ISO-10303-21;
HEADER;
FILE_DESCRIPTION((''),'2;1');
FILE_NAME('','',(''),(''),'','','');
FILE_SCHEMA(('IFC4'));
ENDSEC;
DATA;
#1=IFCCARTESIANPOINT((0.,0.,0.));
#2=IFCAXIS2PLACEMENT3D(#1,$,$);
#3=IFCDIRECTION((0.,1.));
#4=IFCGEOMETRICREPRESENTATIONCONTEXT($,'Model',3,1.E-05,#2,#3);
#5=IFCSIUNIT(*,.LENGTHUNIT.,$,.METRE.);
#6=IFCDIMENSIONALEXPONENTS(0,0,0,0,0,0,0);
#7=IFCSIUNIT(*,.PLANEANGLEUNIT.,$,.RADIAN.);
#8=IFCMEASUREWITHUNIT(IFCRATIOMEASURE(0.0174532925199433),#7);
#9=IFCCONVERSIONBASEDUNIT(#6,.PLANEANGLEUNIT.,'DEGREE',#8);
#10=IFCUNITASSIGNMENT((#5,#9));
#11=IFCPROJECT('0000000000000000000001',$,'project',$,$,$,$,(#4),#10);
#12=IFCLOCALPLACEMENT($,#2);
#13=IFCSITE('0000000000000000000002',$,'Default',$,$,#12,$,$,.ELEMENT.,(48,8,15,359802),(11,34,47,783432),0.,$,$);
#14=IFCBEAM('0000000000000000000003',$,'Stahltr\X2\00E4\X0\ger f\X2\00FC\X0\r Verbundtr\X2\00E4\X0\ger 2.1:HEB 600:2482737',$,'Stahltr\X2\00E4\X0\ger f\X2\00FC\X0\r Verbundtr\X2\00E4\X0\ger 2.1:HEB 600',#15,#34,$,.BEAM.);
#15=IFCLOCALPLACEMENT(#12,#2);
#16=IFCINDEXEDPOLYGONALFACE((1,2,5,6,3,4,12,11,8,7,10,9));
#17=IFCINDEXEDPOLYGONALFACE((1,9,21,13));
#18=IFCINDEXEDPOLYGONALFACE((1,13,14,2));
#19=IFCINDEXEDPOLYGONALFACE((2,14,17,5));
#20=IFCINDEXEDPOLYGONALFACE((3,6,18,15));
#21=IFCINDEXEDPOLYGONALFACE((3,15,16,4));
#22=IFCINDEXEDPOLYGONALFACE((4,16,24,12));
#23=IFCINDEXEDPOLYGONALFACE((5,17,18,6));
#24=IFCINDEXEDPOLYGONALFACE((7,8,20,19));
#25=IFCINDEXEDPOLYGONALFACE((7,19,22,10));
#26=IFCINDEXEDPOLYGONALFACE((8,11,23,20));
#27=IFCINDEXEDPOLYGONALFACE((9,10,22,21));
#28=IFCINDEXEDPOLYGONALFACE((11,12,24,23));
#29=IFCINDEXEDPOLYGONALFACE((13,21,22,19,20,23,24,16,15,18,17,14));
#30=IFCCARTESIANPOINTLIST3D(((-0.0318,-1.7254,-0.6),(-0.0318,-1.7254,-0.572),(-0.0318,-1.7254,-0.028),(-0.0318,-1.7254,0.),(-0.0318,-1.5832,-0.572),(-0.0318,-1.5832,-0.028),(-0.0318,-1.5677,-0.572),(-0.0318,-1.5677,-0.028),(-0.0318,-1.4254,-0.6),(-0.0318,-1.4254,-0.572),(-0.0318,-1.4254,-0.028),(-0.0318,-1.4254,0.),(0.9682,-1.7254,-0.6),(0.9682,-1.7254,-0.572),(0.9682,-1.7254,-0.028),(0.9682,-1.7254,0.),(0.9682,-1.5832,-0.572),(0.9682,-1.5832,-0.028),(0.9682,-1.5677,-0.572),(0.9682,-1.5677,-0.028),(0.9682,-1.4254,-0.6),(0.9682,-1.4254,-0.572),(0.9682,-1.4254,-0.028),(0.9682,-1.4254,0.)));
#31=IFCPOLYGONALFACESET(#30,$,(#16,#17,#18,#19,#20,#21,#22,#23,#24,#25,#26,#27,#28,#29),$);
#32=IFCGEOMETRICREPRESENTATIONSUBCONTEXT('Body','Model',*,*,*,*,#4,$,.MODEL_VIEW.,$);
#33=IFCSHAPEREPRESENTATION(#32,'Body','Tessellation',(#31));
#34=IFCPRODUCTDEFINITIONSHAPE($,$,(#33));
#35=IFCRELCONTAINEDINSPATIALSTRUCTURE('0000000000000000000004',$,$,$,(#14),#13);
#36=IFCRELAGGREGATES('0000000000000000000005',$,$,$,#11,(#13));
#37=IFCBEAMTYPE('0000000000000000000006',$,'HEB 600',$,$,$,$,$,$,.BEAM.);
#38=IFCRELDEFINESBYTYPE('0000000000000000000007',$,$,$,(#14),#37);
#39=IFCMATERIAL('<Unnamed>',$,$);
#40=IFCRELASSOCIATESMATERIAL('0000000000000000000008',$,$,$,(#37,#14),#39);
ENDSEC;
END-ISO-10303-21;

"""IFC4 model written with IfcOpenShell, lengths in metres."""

from ifc_helpers import new_model, entity, si_unit, converted_unit, direction, frame, frame_2d, origin, place, context, subcontext, project, spatial, polyline, segment, composite_curve, i_section, outline, extrude, source, transform, mapped, material, material_profile, profile_set, profile_usage, type_object, type_shapes, element, save


model = new_model("IFC4")

# Units and contexts
model_context = context("Model", 3, precision=1e-05, world=origin(), true_north=direction((0.0, 1.0)))
body_context = subcontext(model_context, "Body", "Model", "MODEL_VIEW")
ifc_project = project(units=[si_unit("LENGTHUNIT", "METRE"), converted_unit("PLANEANGLEUNIT", "DEGREE", entity("IfcRatioMeasure", 0.0174532925199433), si_unit("PLANEANGLEUNIT", "RADIAN"), dimensions=[0, 0, 0, 0, 0, 0, 0])], contexts=[model_context])

# Site
site_placement = place(None, origin())
site = spatial("IfcSite", under=ifc_project, at=site_placement, Name="Default", CompositionType="ELEMENT", RefLatitude=(48, 8, 15, 359802), RefLongitude=(11, 34, 47, 783432), RefElevation=0.0)

# Beam
ifc_material = material(Name="<Unnamed>")
ifc_material_profile_1 = material_profile(ifc_material, outline(composite_curve([segment(polyline([(-0.15, -0.028, 0.0), (-0.15, 0.0, 0.0)]), True, "CONTINUOUS"), segment(polyline([(-0.15, 0.0, 0.0), (0.15, 0.0, 0.0)]), True, "CONTINUOUS"), segment(polyline([(0.15, 0.0, 0.0), (0.15, -0.028, 0.0)]), True, "CONTINUOUS"), segment(polyline([(0.15, -0.028, 0.0), (0.0077, -0.028, 0.0)]), True, "CONTINUOUS"), segment(polyline([(0.0077, -0.028, 0.0), (0.0077, -0.572, 0.0)]), True, "CONTINUOUS"), segment(polyline([(0.0077, -0.572, 0.0), (0.15, -0.572, 0.0)]), True, "CONTINUOUS"), segment(polyline([(0.15, -0.572, 0.0), (0.15, -0.6, 0.0)]), True, "CONTINUOUS"), segment(polyline([(0.15, -0.6, 0.0), (-0.15, -0.6, 0.0)]), True, "CONTINUOUS"), segment(polyline([(-0.15, -0.6, 0.0), (-0.15, -0.572, 0.0)]), True, "CONTINUOUS"), segment(polyline([(-0.15, -0.572, 0.0), (-0.0078, -0.572, 0.0)]), True, "CONTINUOUS"), segment(polyline([(-0.0078, -0.572, 0.0), (-0.0078, -0.028, 0.0)]), True, "CONTINUOUS"), segment(polyline([(-0.0078, -0.028, 0.0), (-0.15, -0.028, 0.0)]), True, "CONTINUOUS")], self_intersect=False), kind="CURVE"), Name="HEB 600")
ifc_material_profile_2 = material_profile(ifc_material, outline(composite_curve([segment(polyline([(-0.5, -0.15, 0.0), (-0.5, 0.15, 0.0)]), True, "CONTINUOUS"), segment(polyline([(-0.5, 0.15, 0.0), (-0.5, 0.15, -0.028)]), True, "CONTINUOUS"), segment(polyline([(-0.5, 0.15, -0.028), (-0.5, 0.0077, -0.028)]), True, "CONTINUOUS"), segment(polyline([(-0.5, 0.0077, -0.028), (-0.5, 0.0077, -0.572)]), True, "CONTINUOUS"), segment(polyline([(-0.5, 0.0077, -0.572), (-0.5, 0.15, -0.572)]), True, "CONTINUOUS"), segment(polyline([(-0.5, 0.15, -0.572), (-0.5, 0.15, -0.6)]), True, "CONTINUOUS"), segment(polyline([(-0.5, 0.15, -0.6), (-0.5, -0.15, -0.6)]), True, "CONTINUOUS"), segment(polyline([(-0.5, -0.15, -0.6), (-0.5, -0.15, -0.572)]), True, "CONTINUOUS"), segment(polyline([(-0.5, -0.15, -0.572), (-0.5, -0.0078, -0.572)]), True, "CONTINUOUS"), segment(polyline([(-0.5, -0.0078, -0.572), (-0.5, -0.0078, -0.028)]), True, "CONTINUOUS"), segment(polyline([(-0.5, -0.0078, -0.028), (-0.5, -0.15, -0.028)]), True, "CONTINUOUS"), segment(polyline([(-0.5, -0.15, -0.028), (-0.5, -0.15, 0.0)]), True, "CONTINUOUS")], self_intersect=False), kind="CURVE"), Name="HEB 600")
ifc_profile_set = profile_set([ifc_material_profile_1, ifc_material_profile_2], Name="HEB 600")
ifc_profile_usage = profile_usage(ifc_profile_set, cardinal=8)
beam_type = type_object("IfcBeamType", Name="HEB 600", PredefinedType="BEAM", material=ifc_profile_set)
shared_shape = source(origin(), body_context, "Body", "SweptSolid", [
    extrude(i_section(OverallWidth=0.3, OverallDepth=0.6, WebThickness=0.0155, FlangeThickness=0.028, at=frame_2d((0.0, 0.0), x_axis=(0.0, 1.0))), frame((-0.5, 0.0, -0.3), z_axis=(1.0, 0.0, 0.0), x_axis=(0.0, 0.0, -1.0)), (0.0, 0.0, 1.0), 1.0),
])
type_shapes(beam_type, [shared_shape])
beam_placement = place(site_placement, frame((0.4682, -1.5754, 0.0)))
element("IfcBeam", 1, at=beam_placement, inside=site, type_object=beam_type, material=ifc_profile_usage, Name="Stahlträger für Verbundträger 2.1:HEB 600:2482737", ObjectType="Stahlträger für Verbundträger 2.1:HEB 600", PredefinedType="BEAM", context=body_context, shape_type="MappedRepresentation", body=[
    mapped(shared_shape, transform((0.0, 0.0, 0.0), scale=1.0)),
])

save(model, "model.ifc")
